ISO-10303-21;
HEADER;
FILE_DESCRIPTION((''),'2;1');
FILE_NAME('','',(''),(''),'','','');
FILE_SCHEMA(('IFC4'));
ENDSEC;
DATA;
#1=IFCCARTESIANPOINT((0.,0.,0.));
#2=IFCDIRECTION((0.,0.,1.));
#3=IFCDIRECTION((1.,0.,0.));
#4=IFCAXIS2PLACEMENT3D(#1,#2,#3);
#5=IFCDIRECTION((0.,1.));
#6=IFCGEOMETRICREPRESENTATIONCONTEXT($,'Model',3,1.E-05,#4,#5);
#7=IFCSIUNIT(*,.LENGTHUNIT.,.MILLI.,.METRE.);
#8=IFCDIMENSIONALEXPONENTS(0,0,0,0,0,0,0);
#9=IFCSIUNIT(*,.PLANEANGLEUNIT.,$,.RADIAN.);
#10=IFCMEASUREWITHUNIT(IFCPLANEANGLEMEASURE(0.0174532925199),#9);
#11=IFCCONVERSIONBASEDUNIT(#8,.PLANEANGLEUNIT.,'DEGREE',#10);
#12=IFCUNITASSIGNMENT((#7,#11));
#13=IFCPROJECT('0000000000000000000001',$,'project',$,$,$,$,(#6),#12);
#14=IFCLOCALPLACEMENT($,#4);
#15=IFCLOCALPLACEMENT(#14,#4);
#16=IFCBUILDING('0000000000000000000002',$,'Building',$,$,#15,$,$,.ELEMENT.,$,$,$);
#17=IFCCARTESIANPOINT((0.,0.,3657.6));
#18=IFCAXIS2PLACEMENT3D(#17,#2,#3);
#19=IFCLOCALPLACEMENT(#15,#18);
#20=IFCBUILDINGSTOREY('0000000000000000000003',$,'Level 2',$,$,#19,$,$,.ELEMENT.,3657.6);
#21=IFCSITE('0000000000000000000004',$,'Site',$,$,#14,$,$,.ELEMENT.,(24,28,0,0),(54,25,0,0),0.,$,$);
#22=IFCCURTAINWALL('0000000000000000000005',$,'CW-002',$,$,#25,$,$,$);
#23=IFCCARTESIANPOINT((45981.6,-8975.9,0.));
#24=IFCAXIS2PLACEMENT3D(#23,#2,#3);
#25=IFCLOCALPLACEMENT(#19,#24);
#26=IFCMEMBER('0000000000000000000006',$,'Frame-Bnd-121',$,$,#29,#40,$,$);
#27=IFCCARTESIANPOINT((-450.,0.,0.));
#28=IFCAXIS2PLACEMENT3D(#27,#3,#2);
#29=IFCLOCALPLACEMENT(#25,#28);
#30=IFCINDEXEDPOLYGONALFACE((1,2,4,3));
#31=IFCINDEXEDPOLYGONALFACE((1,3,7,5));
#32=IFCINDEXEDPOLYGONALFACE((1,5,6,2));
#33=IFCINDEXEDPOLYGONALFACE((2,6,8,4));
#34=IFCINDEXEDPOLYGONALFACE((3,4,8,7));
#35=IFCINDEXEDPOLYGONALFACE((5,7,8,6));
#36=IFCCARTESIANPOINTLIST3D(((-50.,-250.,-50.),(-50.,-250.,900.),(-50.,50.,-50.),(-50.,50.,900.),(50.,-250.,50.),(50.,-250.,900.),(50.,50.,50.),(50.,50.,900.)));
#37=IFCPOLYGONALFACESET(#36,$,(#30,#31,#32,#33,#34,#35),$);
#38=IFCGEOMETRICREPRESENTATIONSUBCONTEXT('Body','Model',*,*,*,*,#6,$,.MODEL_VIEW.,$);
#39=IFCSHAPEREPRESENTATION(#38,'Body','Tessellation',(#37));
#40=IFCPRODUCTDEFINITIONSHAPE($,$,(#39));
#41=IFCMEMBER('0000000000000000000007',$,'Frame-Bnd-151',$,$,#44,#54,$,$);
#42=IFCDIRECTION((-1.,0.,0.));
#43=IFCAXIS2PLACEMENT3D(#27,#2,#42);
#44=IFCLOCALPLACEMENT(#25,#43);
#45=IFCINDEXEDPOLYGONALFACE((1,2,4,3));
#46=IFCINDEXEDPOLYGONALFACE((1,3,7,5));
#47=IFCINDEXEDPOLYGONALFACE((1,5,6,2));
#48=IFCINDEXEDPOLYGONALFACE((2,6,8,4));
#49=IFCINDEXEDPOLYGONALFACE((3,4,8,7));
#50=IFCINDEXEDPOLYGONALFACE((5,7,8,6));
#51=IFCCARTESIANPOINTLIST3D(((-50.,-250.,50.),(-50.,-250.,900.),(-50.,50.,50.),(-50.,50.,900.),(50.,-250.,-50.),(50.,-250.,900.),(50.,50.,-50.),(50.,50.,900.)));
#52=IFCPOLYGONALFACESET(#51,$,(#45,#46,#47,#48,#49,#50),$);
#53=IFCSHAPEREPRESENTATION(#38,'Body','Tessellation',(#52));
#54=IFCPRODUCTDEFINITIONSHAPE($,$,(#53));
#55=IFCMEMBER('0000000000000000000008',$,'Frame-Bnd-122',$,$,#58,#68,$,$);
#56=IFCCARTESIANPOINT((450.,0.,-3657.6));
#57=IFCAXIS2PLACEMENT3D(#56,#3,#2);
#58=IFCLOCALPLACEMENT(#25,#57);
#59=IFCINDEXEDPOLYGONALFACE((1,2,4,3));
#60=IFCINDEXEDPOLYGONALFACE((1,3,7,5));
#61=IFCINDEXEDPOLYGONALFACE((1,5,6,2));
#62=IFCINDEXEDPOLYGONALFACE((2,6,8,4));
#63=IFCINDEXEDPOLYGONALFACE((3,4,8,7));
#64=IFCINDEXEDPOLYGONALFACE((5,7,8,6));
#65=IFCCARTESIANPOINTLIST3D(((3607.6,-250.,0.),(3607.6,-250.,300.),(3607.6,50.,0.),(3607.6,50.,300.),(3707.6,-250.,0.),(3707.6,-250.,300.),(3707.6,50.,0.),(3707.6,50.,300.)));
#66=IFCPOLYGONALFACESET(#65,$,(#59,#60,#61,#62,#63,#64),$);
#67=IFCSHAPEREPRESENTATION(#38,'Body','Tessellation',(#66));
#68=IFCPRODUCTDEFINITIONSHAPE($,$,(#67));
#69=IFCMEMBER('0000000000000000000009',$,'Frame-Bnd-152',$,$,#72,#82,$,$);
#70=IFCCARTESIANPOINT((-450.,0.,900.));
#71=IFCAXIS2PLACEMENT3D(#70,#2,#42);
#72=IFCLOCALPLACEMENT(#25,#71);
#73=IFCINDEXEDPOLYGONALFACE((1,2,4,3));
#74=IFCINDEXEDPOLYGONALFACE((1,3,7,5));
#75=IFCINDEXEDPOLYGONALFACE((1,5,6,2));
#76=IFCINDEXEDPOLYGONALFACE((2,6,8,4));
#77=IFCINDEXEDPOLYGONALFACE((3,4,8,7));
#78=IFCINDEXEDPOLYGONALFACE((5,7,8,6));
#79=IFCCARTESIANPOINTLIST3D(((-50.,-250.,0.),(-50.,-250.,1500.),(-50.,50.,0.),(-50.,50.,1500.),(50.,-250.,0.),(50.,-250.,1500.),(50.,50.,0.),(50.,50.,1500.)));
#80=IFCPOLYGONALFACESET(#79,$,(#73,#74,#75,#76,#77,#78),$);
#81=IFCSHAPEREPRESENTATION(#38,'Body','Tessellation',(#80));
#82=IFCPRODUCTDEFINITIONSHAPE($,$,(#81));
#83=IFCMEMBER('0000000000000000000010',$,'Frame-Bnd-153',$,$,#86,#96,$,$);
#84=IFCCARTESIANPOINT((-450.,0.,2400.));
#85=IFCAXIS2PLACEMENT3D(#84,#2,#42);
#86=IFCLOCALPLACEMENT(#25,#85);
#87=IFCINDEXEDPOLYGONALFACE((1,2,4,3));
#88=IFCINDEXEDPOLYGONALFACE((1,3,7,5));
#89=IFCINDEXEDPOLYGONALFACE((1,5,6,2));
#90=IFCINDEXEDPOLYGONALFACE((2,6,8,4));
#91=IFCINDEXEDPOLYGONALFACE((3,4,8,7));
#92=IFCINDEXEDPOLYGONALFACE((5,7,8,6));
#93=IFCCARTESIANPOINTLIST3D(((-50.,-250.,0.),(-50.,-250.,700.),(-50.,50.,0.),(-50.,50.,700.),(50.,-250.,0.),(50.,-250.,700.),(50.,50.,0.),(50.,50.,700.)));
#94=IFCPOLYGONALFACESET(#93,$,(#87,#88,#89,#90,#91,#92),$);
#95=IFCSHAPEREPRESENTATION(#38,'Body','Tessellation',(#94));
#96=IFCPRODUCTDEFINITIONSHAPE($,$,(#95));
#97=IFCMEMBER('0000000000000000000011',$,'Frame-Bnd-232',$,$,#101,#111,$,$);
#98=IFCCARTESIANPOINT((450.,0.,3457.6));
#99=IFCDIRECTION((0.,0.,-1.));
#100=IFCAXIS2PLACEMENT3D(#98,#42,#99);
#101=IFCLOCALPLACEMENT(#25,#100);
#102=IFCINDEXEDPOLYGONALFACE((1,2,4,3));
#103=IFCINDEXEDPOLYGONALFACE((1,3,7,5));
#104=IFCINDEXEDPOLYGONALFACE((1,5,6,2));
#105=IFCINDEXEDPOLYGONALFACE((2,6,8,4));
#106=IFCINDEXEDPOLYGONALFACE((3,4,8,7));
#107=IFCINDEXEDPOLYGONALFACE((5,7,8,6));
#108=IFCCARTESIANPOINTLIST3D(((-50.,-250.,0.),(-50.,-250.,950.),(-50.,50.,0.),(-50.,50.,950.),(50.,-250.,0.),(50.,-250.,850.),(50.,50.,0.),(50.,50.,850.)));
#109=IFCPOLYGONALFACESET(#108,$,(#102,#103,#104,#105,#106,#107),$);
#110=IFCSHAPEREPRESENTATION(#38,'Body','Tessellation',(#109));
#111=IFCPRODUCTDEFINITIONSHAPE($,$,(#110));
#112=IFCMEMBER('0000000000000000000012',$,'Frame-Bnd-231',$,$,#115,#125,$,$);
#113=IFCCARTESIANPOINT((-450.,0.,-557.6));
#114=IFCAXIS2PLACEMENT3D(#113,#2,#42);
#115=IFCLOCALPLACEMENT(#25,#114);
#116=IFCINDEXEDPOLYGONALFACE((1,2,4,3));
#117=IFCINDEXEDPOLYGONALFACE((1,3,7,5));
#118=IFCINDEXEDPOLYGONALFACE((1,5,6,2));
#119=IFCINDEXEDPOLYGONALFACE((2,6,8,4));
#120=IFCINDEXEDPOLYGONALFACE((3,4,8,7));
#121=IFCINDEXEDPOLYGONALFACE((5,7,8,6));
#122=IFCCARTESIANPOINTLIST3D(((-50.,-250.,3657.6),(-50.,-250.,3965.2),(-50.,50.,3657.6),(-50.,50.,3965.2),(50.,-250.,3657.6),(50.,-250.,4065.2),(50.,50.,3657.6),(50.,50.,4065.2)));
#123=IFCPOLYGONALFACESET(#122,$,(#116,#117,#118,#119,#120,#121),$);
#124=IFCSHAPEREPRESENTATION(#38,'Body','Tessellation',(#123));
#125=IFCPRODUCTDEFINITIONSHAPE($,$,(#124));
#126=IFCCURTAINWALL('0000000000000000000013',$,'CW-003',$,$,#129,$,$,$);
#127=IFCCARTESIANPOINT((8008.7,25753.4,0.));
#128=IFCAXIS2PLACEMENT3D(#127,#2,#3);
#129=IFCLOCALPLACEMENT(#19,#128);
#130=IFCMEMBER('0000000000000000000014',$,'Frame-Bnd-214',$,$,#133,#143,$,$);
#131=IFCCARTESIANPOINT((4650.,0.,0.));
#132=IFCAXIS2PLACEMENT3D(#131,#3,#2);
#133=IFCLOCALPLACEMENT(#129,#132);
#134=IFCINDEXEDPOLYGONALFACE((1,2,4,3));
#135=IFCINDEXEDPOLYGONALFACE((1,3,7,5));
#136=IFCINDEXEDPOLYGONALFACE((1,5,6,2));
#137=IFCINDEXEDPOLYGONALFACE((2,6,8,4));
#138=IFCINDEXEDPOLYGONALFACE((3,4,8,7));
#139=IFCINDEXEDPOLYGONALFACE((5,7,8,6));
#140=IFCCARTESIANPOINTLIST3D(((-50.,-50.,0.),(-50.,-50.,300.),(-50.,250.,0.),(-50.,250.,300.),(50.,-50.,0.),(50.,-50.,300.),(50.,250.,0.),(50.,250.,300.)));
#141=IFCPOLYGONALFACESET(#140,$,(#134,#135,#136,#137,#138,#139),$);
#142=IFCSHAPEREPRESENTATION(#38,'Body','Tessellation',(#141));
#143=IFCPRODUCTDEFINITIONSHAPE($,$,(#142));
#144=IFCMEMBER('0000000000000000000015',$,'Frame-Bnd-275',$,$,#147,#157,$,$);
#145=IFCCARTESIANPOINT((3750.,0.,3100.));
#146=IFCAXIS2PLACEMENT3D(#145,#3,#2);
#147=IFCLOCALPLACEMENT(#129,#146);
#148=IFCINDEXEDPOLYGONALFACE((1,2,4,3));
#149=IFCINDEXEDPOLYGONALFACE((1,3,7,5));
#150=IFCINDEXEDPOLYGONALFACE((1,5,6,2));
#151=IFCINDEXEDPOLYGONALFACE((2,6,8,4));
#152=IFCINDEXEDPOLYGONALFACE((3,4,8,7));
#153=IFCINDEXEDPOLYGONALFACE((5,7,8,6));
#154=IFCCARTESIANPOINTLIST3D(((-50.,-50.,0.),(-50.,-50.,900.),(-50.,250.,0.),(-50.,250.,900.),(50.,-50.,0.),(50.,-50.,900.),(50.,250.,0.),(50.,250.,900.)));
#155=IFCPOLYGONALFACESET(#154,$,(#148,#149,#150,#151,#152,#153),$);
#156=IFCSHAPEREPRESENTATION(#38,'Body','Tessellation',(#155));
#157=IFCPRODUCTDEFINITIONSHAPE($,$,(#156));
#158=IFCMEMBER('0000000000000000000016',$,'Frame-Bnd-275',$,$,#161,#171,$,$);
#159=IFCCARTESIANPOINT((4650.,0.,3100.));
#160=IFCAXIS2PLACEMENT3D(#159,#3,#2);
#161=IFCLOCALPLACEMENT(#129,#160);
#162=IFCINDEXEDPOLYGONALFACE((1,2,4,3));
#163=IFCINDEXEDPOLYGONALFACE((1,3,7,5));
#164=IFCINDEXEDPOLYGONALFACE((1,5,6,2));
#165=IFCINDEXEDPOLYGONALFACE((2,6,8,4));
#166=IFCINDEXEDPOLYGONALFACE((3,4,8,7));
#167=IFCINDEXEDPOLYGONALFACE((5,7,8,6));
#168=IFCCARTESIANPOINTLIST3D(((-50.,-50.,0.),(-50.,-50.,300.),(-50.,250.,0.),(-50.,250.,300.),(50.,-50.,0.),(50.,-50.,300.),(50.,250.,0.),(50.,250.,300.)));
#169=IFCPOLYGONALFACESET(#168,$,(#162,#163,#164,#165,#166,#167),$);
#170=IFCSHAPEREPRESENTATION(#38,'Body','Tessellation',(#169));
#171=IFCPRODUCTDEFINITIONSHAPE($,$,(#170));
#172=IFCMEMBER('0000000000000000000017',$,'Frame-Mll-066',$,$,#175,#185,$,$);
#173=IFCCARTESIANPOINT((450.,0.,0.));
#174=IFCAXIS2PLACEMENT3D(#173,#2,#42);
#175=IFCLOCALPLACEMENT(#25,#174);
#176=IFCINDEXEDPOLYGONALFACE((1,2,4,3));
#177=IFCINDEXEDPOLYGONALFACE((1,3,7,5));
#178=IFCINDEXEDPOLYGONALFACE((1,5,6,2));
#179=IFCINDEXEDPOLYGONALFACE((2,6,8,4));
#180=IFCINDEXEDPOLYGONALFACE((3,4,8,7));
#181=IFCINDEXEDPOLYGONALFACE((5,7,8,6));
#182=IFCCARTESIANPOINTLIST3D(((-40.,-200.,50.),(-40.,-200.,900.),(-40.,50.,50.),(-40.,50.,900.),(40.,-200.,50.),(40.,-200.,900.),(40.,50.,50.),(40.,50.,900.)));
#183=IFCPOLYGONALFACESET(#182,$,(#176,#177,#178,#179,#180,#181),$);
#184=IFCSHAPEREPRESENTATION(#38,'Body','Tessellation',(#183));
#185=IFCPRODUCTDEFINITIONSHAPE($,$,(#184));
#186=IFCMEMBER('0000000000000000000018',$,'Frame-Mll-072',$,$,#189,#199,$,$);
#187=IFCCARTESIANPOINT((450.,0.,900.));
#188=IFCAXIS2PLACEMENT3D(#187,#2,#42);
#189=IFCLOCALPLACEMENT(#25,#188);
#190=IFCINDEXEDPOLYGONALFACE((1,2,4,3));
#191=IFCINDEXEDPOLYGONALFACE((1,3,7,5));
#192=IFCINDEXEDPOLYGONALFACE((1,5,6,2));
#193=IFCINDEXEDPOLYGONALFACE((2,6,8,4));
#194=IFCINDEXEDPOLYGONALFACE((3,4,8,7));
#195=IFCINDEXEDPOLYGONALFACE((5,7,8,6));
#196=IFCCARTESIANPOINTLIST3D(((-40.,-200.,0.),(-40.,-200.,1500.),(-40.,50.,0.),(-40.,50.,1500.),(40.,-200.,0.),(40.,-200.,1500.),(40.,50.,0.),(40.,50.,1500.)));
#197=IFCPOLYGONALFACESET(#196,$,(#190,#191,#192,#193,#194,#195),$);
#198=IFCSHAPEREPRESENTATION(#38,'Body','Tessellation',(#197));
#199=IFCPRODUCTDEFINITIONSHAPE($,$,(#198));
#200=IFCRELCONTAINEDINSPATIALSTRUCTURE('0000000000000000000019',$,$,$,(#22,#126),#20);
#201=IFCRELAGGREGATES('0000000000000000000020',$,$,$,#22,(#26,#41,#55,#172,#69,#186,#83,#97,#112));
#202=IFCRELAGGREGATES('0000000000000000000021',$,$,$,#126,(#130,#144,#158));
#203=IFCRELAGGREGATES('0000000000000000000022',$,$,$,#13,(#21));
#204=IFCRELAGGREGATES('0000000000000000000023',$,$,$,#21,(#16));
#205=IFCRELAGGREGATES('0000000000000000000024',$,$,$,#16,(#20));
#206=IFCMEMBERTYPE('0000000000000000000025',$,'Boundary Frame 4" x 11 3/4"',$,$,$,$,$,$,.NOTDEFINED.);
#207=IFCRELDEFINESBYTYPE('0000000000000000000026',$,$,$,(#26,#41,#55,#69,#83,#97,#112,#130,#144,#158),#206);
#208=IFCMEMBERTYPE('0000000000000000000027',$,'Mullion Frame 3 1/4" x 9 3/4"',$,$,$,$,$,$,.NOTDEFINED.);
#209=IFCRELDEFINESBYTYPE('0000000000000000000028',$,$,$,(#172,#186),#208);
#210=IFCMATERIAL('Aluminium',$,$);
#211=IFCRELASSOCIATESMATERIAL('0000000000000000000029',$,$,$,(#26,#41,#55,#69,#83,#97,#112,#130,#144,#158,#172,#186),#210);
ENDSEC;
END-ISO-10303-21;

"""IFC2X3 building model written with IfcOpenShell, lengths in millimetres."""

from ifc_helpers import new_model, entity, si_unit, converted_unit, direction, frame, origin_with_axes, place, context, subcontext, project, spatial, polyline, outline, extrude, clip, halfspace, material, type_object, element, aggregate, save


model = new_model("IFC2X3")

# Units and contexts
model_context = context("Model", 3, precision=1e-05, world=origin_with_axes(), true_north=direction((0.0, 1.0)))
body_context = subcontext(model_context, "Body", "Model", "MODEL_VIEW")
ifc_project = project(units=[si_unit("LENGTHUNIT", "METRE", prefix="MILLI"), converted_unit("PLANEANGLEUNIT", "DEGREE", entity("IfcPlaneAngleMeasure", 0.0174532925199), si_unit("PLANEANGLEUNIT", "RADIAN"), dimensions=[0, 0, 0, 0, 0, 0, 0])], contexts=[model_context])

# Site, building, storey
site_placement = place(None, origin_with_axes())
site = spatial("IfcSite", under=ifc_project, at=site_placement, Name="Site", CompositionType="ELEMENT", RefLatitude=(24, 28, 0, 0), RefLongitude=(54, 25, 0, 0), RefElevation=0.0)
building_placement = place(site_placement, origin_with_axes())
building = spatial("IfcBuilding", under=site, at=building_placement, Name="Building", CompositionType="ELEMENT")
storey_placement = place(building_placement, frame((0.0, 0.0, 3657.6), z_axis=(0.0, 0.0, 1.0), x_axis=(1.0, 0.0, 0.0)))
storey = spatial("IfcBuildingStorey", under=building, at=storey_placement, Name="Level 2", CompositionType="ELEMENT", Elevation=3657.6)

# Curtain walls, members
curtain_wall_1_placement = place(storey_placement, frame((45981.6, -8975.9, 0.0), z_axis=(0.0, 0.0, 1.0), x_axis=(1.0, 0.0, 0.0)))
curtain_wall_1 = element("IfcCurtainWall", 1, at=curtain_wall_1_placement, inside=storey, Name="CW-002")
ifc_material_1 = material(Name="Aluminium")
member_type_1 = type_object("IfcMemberType", Name="Boundary Frame 4\" x 11 3/4\"", PredefinedType="NOTDEFINED")
member_1_placement = place(curtain_wall_1_placement, frame((-450.0, 0.0, 0.0), z_axis=(1.0, 0.0, 0.0), x_axis=(0.0, 0.0, 1.0)))
member_1 = element("IfcMember", 2, at=member_1_placement, type_object=member_type_1, material=ifc_material_1, Name="Frame-Bnd-121", context=body_context, shape_type="Clipping", body=[
    clip(extrude(outline(polyline([(-250.0, -50.0), (50.0, -50.0), (50.0, 50.0), (-250.0, 50.0), (-250.0, -50.0)])), frame((0.0, 0.0, -50.0), z_axis=(0.0, 0.0, 1.0), x_axis=(0.0, 1.0, 0.0)), (0.0, 0.0, 1.0), 950.0), halfspace(frame((0.0, 0.0, 0.0), z_axis=(-0.707107, 0.0, 0.707107), x_axis=(0.0, -1.0, 0.0)), True)),
])
member_2_placement = place(curtain_wall_1_placement, frame((-450.0, 0.0, 0.0), z_axis=(0.0, 0.0, 1.0), x_axis=(-1.0, 0.0, 0.0)))
member_2 = element("IfcMember", 3, at=member_2_placement, type_object=member_type_1, material=ifc_material_1, Name="Frame-Bnd-151", context=body_context, shape_type="Clipping", body=[
    clip(extrude(outline(polyline([(-50.0, 250.0), (-50.0, -50.0), (50.0, -50.0), (50.0, 250.0), (-50.0, 250.0)])), frame((0.0, 0.0, -50.0), z_axis=(0.0, 0.0, 1.0), x_axis=(-1.0, 0.0, 0.0)), (0.0, 0.0, 1.0), 950.0), halfspace(frame((0.0, 0.0, 0.0), z_axis=(0.707107, 0.0, 0.707107), x_axis=(0.0, -1.0, 0.0)), True)),
])
member_3_placement = place(curtain_wall_1_placement, frame((450.0, 0.0, -3657.6), z_axis=(1.0, 0.0, 0.0), x_axis=(0.0, 0.0, 1.0)))
member_3 = element("IfcMember", 4, at=member_3_placement, type_object=member_type_1, material=ifc_material_1, Name="Frame-Bnd-122", context=body_context, shape_type="SweptSolid", body=[
    extrude(outline(polyline([(-250.0, -3707.6), (50.0, -3707.6), (50.0, -3607.6), (-250.0, -3607.6), (-250.0, -3707.6)])), frame((0.0, 0.0, 0.0), z_axis=(0.0, 0.0, 1.0), x_axis=(0.0, 1.0, 0.0)), (0.0, 0.0, 1.0), 300.0),
])
member_4_placement = place(curtain_wall_1_placement, frame((-450.0, 0.0, 900.0), z_axis=(0.0, 0.0, 1.0), x_axis=(-1.0, 0.0, 0.0)))
member_4 = element("IfcMember", 5, at=member_4_placement, type_object=member_type_1, material=ifc_material_1, Name="Frame-Bnd-152", context=body_context, shape_type="SweptSolid", body=[
    extrude(outline(polyline([(-50.0, 250.0), (-50.0, -50.0), (50.0, -50.0), (50.0, 250.0), (-50.0, 250.0)])), frame((0.0, 0.0, 0.0), z_axis=(0.0, 0.0, 1.0), x_axis=(-1.0, 0.0, 0.0)), (0.0, 0.0, 1.0), 1500.0),
])
member_5_placement = place(curtain_wall_1_placement, frame((-450.0, 0.0, 2400.0), z_axis=(0.0, 0.0, 1.0), x_axis=(-1.0, 0.0, 0.0)))
member_5 = element("IfcMember", 6, at=member_5_placement, type_object=member_type_1, material=ifc_material_1, Name="Frame-Bnd-153", context=body_context, shape_type="SweptSolid", body=[
    extrude(outline(polyline([(-50.0, 250.0), (-50.0, -50.0), (50.0, -50.0), (50.0, 250.0), (-50.0, 250.0)])), frame((0.0, 0.0, 0.0), z_axis=(0.0, 0.0, 1.0), x_axis=(-1.0, 0.0, 0.0)), (0.0, 0.0, 1.0), 700.0),
])
member_6_placement = place(curtain_wall_1_placement, frame((450.0, 0.0, 3457.6), z_axis=(-1.0, 0.0, 0.0), x_axis=(0.0, 0.0, -1.0)))
member_6 = element("IfcMember", 7, at=member_6_placement, type_object=member_type_1, material=ifc_material_1, Name="Frame-Bnd-232", context=body_context, shape_type="Clipping", body=[
    clip(extrude(outline(polyline([(250.0, 50.0), (-50.0, 50.0), (-50.0, -50.0), (250.0, -50.0), (250.0, 50.0)])), frame((0.0, 0.0, 0.0), z_axis=(0.0, 0.0, 1.0), x_axis=(0.0, -1.0, 0.0)), (0.0, 0.0, 1.0), 950.0), halfspace(frame((450.0, 0.0, 450.0), z_axis=(-0.707107, 0.0, -0.707107), x_axis=(0.0, 1.0, 0.0)), True)),
])
member_7_placement = place(curtain_wall_1_placement, frame((-450.0, 0.0, -557.6), z_axis=(0.0, 0.0, 1.0), x_axis=(-1.0, 0.0, 0.0)))
member_7 = element("IfcMember", 8, at=member_7_placement, type_object=member_type_1, material=ifc_material_1, Name="Frame-Bnd-231", context=body_context, shape_type="Clipping", body=[
    clip(extrude(outline(polyline([(-50.0, 250.0), (-50.0, -50.0), (50.0, -50.0), (50.0, 250.0), (-50.0, 250.0)])), frame((0.0, 0.0, 3657.6), z_axis=(0.0, 0.0, 1.0), x_axis=(-1.0, 0.0, 0.0)), (0.0, 0.0, 1.0), 407.6), halfspace(frame((-2007.6, 0.0, 2007.6), z_axis=(0.707107, 0.0, -0.707107), x_axis=(0.0, 1.0, 0.0)), True)),
])
curtain_wall_2_placement = place(storey_placement, frame((8008.7, 25753.4, 0.0), z_axis=(0.0, 0.0, 1.0), x_axis=(1.0, 0.0, 0.0)))
curtain_wall_2 = element("IfcCurtainWall", 9, at=curtain_wall_2_placement, inside=storey, Name="CW-003")
member_8_placement = place(curtain_wall_2_placement, frame((4650.0, 0.0, 0.0), z_axis=(1.0, 0.0, 0.0), x_axis=(0.0, 0.0, 1.0)))
member_8 = element("IfcMember", 10, at=member_8_placement, type_object=member_type_1, material=ifc_material_1, Name="Frame-Bnd-214", context=body_context, shape_type="SweptSolid", body=[
    extrude(outline(polyline([(250.0, -50.0), (250.0, 50.0), (-50.0, 50.0), (-50.0, -50.0), (250.0, -50.0)])), frame((0.0, 0.0, 0.0), z_axis=(0.0, 0.0, 1.0), x_axis=(0.0, 1.0, 0.0)), (0.0, 0.0, 1.0), 300.0),
])
member_9_placement = place(curtain_wall_2_placement, frame((3750.0, 0.0, 3100.0), z_axis=(1.0, 0.0, 0.0), x_axis=(0.0, 0.0, 1.0)))
member_9 = element("IfcMember", 11, at=member_9_placement, type_object=member_type_1, material=ifc_material_1, Name="Frame-Bnd-275", context=body_context, shape_type="SweptSolid", body=[
    extrude(outline(polyline([(250.0, -50.0), (250.0, 50.0), (-50.0, 50.0), (-50.0, -50.0), (250.0, -50.0)])), frame((0.0, 0.0, 0.0), z_axis=(0.0, 0.0, 1.0), x_axis=(0.0, 1.0, 0.0)), (0.0, 0.0, 1.0), 900.0),
])
member_10_placement = place(curtain_wall_2_placement, frame((4650.0, 0.0, 3100.0), z_axis=(1.0, 0.0, 0.0), x_axis=(0.0, 0.0, 1.0)))
member_10 = element("IfcMember", 12, at=member_10_placement, type_object=member_type_1, material=ifc_material_1, Name="Frame-Bnd-275", context=body_context, shape_type="SweptSolid", body=[
    extrude(outline(polyline([(250.0, -50.0), (250.0, 50.0), (-50.0, 50.0), (-50.0, -50.0), (250.0, -50.0)])), frame((0.0, 0.0, 0.0), z_axis=(0.0, 0.0, 1.0), x_axis=(0.0, 1.0, 0.0)), (0.0, 0.0, 1.0), 300.0),
])

# Members
member_type_2 = type_object("IfcMemberType", Name="Mullion Frame 3 1/4\" x 9 3/4\"", PredefinedType="NOTDEFINED")
member_11_placement = place(curtain_wall_1_placement, frame((450.0, 0.0, 0.0), z_axis=(0.0, 0.0, 1.0), x_axis=(-1.0, 0.0, 0.0)))
member_11 = element("IfcMember", 13, at=member_11_placement, type_object=member_type_2, material=ifc_material_1, Name="Frame-Mll-066", context=body_context, shape_type="SweptSolid", body=[
    extrude(outline(polyline([(-40.0, 200.0), (-40.0, -50.0), (40.0, -50.0), (40.0, 200.0), (-40.0, 200.0)])), frame((0.0, 0.0, 50.0), z_axis=(0.0, 0.0, 1.0), x_axis=(-1.0, 0.0, 0.0)), (0.0, 0.0, 1.0), 850.0),
])
member_12_placement = place(curtain_wall_1_placement, frame((450.0, 0.0, 900.0), z_axis=(0.0, 0.0, 1.0), x_axis=(-1.0, 0.0, 0.0)))
member_12 = element("IfcMember", 14, at=member_12_placement, type_object=member_type_2, material=ifc_material_1, Name="Frame-Mll-072", context=body_context, shape_type="SweptSolid", body=[
    extrude(outline(polyline([(-40.0, 200.0), (-40.0, -50.0), (40.0, -50.0), (40.0, 200.0), (-40.0, 200.0)])), frame((0.0, 0.0, 0.0), z_axis=(0.0, 0.0, 1.0), x_axis=(-1.0, 0.0, 0.0)), (0.0, 0.0, 1.0), 1500.0),
])

aggregate(curtain_wall_1, [member_1, member_2, member_3, member_11, member_4, member_12, member_5, member_6, member_7])
aggregate(curtain_wall_2, [member_8, member_9, member_10])

save(model, "model.ifc")
